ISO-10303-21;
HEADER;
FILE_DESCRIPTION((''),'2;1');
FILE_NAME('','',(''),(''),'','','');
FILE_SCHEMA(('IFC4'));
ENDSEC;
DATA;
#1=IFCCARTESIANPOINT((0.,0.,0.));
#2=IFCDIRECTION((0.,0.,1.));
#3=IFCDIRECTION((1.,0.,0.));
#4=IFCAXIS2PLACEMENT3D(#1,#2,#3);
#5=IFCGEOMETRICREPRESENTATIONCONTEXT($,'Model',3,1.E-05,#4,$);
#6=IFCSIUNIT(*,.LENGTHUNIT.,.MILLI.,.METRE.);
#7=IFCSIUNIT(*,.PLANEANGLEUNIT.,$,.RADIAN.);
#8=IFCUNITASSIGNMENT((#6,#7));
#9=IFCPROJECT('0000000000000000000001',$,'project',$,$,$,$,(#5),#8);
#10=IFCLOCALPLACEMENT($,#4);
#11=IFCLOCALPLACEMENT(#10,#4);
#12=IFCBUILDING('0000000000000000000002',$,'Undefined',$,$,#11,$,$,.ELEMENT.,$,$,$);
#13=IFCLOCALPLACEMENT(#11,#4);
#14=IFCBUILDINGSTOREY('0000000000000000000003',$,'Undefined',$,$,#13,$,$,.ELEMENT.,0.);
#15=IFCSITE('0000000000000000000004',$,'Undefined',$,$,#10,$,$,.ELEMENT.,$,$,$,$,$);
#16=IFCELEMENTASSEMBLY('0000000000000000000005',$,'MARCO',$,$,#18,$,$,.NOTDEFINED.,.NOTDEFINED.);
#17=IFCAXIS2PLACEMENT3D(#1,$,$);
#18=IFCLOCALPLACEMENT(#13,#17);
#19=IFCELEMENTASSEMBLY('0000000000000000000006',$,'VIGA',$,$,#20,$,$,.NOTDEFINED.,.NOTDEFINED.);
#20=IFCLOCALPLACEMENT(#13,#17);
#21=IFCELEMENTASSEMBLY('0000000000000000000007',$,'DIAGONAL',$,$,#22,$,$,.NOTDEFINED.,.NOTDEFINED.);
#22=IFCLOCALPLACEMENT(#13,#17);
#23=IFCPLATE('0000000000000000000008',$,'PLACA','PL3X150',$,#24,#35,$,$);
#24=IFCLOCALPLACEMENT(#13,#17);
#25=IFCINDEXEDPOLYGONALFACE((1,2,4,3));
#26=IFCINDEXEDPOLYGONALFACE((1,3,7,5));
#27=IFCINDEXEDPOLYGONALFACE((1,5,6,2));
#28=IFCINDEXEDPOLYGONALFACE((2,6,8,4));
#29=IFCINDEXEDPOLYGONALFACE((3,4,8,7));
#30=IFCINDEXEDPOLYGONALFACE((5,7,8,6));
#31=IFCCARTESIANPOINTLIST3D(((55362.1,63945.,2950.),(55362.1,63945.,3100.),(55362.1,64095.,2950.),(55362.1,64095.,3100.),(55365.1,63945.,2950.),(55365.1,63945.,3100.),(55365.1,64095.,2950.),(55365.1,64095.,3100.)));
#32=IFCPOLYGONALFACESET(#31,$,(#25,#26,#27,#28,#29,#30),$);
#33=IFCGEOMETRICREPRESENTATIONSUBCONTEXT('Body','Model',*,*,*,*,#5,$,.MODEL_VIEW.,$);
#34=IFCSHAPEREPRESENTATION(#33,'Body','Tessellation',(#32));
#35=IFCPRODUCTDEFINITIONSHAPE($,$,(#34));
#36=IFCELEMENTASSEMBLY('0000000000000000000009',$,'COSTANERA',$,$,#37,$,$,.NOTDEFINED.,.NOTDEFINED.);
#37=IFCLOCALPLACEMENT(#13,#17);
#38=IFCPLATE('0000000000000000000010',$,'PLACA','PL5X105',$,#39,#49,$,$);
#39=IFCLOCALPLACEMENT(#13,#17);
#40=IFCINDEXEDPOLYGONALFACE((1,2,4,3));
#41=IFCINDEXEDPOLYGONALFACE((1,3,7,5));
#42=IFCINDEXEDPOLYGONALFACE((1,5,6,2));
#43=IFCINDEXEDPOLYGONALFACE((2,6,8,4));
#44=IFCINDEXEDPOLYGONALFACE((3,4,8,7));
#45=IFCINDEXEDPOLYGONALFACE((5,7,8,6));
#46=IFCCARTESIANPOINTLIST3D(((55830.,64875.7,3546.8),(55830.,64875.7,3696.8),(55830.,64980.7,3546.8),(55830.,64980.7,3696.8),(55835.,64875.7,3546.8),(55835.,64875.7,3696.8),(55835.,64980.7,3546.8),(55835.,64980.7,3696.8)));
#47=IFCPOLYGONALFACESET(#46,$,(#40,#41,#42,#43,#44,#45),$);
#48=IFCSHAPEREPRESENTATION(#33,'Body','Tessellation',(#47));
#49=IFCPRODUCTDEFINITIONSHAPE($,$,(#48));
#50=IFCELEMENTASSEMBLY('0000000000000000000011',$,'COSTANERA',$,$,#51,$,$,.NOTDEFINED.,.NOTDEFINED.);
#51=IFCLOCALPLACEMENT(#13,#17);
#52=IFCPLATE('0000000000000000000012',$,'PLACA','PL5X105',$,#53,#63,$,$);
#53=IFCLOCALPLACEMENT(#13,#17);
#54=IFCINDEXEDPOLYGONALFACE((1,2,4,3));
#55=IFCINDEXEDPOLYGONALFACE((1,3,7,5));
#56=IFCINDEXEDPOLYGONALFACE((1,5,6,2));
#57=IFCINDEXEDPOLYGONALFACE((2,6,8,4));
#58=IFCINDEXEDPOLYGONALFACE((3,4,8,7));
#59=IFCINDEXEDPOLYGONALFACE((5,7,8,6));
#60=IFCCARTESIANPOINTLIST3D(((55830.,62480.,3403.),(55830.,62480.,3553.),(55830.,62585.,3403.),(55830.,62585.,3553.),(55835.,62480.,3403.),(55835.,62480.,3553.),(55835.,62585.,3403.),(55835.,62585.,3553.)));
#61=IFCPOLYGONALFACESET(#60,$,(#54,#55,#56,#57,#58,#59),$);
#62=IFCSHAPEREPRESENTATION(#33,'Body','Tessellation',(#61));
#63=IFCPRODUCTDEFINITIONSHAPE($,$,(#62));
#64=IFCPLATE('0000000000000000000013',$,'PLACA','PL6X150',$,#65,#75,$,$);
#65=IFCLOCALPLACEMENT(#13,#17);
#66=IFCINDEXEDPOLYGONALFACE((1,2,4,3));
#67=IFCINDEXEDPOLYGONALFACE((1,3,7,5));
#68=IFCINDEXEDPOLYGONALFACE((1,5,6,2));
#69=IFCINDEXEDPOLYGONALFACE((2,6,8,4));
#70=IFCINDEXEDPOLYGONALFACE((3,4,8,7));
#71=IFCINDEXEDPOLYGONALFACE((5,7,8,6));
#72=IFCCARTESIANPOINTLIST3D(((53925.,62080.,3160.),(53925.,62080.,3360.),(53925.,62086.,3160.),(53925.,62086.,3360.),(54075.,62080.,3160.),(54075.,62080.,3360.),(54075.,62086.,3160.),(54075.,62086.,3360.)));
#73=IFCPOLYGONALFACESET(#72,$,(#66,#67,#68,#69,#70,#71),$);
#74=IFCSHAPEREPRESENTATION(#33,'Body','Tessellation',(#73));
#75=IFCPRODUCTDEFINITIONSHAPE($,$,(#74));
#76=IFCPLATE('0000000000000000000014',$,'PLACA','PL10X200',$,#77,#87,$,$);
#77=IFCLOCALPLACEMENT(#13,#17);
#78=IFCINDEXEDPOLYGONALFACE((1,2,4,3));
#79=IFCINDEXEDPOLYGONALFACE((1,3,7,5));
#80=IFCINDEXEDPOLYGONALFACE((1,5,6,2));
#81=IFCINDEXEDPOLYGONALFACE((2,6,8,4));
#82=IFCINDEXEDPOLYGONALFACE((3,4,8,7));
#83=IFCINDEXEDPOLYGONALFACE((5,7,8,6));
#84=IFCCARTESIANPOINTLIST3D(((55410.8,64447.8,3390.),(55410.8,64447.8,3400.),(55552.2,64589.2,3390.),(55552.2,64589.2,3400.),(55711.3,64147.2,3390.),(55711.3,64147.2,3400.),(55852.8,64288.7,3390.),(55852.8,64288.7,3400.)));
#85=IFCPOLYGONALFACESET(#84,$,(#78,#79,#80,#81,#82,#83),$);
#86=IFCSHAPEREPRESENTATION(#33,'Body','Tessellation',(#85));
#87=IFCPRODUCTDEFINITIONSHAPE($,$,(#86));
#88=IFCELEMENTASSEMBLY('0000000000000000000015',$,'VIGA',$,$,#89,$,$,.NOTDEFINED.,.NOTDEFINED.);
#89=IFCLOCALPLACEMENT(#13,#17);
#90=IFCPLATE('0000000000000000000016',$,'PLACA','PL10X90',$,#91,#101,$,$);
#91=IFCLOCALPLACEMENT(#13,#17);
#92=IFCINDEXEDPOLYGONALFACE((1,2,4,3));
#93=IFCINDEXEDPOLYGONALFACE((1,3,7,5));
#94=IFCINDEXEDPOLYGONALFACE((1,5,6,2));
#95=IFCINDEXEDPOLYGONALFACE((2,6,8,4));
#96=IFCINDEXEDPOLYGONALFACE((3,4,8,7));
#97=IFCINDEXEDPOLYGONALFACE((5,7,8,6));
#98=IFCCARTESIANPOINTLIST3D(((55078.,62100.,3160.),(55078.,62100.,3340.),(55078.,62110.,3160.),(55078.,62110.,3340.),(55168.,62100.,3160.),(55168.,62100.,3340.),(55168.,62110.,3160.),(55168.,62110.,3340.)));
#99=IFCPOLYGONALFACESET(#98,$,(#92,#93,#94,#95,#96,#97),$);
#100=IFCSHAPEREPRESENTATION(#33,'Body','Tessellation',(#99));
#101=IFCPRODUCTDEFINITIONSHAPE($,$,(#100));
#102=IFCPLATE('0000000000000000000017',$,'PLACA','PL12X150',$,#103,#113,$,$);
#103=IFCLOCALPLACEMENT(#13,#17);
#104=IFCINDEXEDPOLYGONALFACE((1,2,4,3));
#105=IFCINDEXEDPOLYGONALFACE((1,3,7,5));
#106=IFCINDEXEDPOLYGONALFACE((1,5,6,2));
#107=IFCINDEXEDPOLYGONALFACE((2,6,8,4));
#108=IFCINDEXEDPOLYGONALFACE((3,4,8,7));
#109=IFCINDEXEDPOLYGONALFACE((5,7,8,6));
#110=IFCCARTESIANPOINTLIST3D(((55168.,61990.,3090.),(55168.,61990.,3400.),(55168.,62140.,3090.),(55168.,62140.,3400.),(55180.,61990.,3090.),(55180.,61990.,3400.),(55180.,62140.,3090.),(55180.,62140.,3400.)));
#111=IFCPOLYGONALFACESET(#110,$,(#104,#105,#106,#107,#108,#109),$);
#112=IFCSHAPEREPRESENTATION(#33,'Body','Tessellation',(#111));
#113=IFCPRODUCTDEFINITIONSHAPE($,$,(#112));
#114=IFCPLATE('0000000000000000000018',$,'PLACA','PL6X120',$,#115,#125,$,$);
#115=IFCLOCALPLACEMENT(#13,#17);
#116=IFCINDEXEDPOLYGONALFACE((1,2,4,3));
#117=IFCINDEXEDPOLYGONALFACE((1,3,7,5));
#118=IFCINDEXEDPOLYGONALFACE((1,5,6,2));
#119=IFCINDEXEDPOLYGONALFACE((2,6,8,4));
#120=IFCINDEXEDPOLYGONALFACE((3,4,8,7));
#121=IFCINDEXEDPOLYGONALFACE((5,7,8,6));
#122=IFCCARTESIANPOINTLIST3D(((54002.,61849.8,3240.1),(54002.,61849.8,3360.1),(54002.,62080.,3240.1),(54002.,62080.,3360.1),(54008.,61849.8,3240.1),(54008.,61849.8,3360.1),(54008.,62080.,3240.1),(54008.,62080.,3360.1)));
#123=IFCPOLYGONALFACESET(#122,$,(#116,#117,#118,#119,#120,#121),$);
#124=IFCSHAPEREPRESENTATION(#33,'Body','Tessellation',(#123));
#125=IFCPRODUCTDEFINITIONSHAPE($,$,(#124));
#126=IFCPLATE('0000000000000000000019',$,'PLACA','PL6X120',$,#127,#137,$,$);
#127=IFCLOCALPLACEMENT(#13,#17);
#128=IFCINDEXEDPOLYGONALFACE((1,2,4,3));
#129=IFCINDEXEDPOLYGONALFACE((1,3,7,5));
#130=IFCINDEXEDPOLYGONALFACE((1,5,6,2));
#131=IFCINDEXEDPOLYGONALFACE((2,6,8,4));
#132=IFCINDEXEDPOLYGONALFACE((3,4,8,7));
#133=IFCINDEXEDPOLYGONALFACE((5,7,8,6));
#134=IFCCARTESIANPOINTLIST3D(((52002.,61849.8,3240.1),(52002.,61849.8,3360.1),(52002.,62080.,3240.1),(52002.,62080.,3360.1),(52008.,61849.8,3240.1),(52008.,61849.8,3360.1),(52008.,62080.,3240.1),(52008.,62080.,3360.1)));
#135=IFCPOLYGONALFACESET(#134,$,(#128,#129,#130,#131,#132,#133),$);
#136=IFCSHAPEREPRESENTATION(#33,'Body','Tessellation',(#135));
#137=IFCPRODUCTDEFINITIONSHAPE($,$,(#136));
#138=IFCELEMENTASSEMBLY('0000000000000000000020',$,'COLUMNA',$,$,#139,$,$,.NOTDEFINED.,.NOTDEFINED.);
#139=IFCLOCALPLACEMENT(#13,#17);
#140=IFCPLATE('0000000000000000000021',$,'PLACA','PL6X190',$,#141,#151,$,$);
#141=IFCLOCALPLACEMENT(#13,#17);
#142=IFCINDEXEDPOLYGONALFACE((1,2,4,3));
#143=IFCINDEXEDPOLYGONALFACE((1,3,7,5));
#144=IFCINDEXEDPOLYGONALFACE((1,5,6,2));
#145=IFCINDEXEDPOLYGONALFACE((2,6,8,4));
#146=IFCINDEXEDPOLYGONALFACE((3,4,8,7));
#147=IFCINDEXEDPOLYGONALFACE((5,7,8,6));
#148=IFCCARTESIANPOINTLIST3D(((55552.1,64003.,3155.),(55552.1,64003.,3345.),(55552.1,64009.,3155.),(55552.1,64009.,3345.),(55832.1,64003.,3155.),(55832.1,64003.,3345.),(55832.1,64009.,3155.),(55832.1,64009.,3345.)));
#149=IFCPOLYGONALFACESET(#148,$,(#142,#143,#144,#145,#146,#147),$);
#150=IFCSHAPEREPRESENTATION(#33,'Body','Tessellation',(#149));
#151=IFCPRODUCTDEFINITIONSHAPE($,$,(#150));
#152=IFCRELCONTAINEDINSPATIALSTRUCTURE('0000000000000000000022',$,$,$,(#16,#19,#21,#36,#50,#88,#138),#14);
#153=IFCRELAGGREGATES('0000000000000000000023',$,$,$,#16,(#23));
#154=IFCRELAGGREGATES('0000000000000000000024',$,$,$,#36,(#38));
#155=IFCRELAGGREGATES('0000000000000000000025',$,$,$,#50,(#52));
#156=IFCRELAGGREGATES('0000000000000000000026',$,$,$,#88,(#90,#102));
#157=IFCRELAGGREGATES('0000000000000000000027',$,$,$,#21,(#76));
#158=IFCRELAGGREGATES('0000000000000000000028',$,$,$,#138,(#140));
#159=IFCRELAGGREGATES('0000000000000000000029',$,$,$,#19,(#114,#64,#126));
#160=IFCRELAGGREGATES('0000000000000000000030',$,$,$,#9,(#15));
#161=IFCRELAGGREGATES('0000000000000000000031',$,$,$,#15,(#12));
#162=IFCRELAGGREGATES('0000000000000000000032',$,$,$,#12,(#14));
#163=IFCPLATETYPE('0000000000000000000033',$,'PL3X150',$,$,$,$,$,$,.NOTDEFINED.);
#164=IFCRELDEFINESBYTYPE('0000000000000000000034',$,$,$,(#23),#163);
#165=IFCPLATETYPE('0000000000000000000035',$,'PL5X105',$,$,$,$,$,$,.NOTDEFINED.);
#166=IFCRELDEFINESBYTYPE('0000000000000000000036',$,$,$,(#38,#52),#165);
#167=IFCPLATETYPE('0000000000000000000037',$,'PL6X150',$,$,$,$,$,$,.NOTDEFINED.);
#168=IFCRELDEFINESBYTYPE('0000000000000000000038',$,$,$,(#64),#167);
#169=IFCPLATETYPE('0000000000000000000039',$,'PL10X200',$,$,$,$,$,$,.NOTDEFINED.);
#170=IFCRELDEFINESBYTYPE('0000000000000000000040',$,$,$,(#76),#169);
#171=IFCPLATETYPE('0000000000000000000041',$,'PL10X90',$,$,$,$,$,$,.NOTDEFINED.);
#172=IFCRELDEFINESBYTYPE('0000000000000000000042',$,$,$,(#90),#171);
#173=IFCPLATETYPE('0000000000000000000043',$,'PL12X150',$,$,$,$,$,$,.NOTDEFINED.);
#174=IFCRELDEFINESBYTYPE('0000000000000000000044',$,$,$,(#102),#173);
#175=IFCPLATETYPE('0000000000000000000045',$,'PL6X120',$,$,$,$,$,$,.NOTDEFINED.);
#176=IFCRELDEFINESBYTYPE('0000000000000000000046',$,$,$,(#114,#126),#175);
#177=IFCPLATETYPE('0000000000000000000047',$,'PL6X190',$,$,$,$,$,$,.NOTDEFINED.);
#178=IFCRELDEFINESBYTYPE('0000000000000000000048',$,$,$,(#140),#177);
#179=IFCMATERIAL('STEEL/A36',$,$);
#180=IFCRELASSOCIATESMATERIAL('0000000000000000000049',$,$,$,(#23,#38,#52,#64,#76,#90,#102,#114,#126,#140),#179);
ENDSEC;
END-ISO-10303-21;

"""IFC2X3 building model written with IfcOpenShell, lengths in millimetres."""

from ifc_helpers import new_model, si_unit, frame, origin_with_axes, origin_2d_with_axis, place, context, subcontext, project, spatial, polyline, rectangle, outline, extrude, material, type_object, element, aggregate, save


model = new_model("IFC2X3")

# Units and contexts
model_context = context("Model", 3, precision=1e-05, world=origin_with_axes())
body_context = subcontext(model_context, "Body", "Model", "MODEL_VIEW")
ifc_project = project(units=[si_unit("LENGTHUNIT", "METRE", prefix="MILLI"), si_unit("PLANEANGLEUNIT", "RADIAN")], contexts=[model_context])

# Site, building, storey
site_placement = place(None, origin_with_axes())
site = spatial("IfcSite", under=ifc_project, at=site_placement, Name="Undefined", CompositionType="ELEMENT")
building_placement = place(site_placement, origin_with_axes())
building = spatial("IfcBuilding", under=site, at=building_placement, Name="Undefined", CompositionType="ELEMENT")
storey_placement = place(building_placement, origin_with_axes())
storey = spatial("IfcBuildingStorey", under=building, at=storey_placement, Name="Undefined", CompositionType="ELEMENT", Elevation=0.0)

# Element assembly
assembly_1_placement = place(storey_placement, origin_with_axes())
assembly_1 = element("IfcElementAssembly", 1, at=assembly_1_placement, inside=storey, Name="MARCO", AssemblyPlace="NOTDEFINED", PredefinedType="NOTDEFINED")
ifc_material_1 = material(Name="STEEL/A36")

# Element assembly
assembly_2_placement = place(storey_placement, origin_with_axes())
assembly_2 = element("IfcElementAssembly", 2, at=assembly_2_placement, inside=storey, Name="VIGA", AssemblyPlace="NOTDEFINED", PredefinedType="NOTDEFINED")

# Element assembly
assembly_3_placement = place(storey_placement, origin_with_axes())
assembly_3 = element("IfcElementAssembly", 3, at=assembly_3_placement, inside=storey, Name="DIAGONAL", AssemblyPlace="NOTDEFINED", PredefinedType="NOTDEFINED")

# Plate
plate_type_1 = type_object("IfcPlateType", Name="PL3X150", PredefinedType="NOTDEFINED")
plate_1_placement = place(assembly_1_placement, frame((55363.6, 64095.0, 2950.0), z_axis=(-1.0, 0.0, 0.0), x_axis=(0.0, -1.0, 0.0)))
plate_1 = element("IfcPlate", 4, at=plate_1_placement, type_object=plate_type_1, material=ifc_material_1, Name="PLACA", Description="PL3X150", context=body_context, shape_type="SweptSolid", body=[
    extrude(outline(polyline([(0.0, 0.0), (150.0, 0.0), (150.0, 150.0), (0.0, 150.0), (0.0, 0.0)])), frame((0.0, 0.0, -1.5), z_axis=(0.0, 0.0, 1.0), x_axis=(1.0, 0.0, 0.0)), (0.0, 0.0, 1.0), 3.0),
])
aggregate(assembly_1, [plate_1])

# Element assemblies, plates
assembly_4_placement = place(storey_placement, origin_with_axes())
assembly_4 = element("IfcElementAssembly", 5, at=assembly_4_placement, inside=storey, Name="COSTANERA", AssemblyPlace="NOTDEFINED", PredefinedType="NOTDEFINED")
plate_type_2 = type_object("IfcPlateType", Name="PL5X105", PredefinedType="NOTDEFINED")
plate_2_placement = place(assembly_4_placement, frame((55832.5, 64980.7, 3546.8), z_axis=(-1.0, 0.0, 0.0), x_axis=(0.0, -1.0, 0.0)))
plate_2 = element("IfcPlate", 6, at=plate_2_placement, type_object=plate_type_2, material=ifc_material_1, Name="PLACA", Description="PL5X105", context=body_context, shape_type="SweptSolid", body=[
    extrude(outline(polyline([(0.0, 0.0), (105.0, 0.0), (105.0, 150.0), (0.0, 150.0), (0.0, 0.0)])), frame((0.0, 0.0, -2.5), z_axis=(0.0, 0.0, 1.0), x_axis=(1.0, 0.0, 0.0)), (0.0, 0.0, 1.0), 5.0),
])
aggregate(assembly_4, [plate_2])
assembly_5_placement = place(storey_placement, origin_with_axes())
assembly_5 = element("IfcElementAssembly", 7, at=assembly_5_placement, inside=storey, Name="COSTANERA", AssemblyPlace="NOTDEFINED", PredefinedType="NOTDEFINED")
plate_3_placement = place(assembly_5_placement, frame((55832.5, 62585.0, 3403.0), z_axis=(-1.0, 0.0, 0.0), x_axis=(0.0, -1.0, 0.0)))
plate_3 = element("IfcPlate", 8, at=plate_3_placement, type_object=plate_type_2, material=ifc_material_1, Name="PLACA", Description="PL5X105", context=body_context, shape_type="SweptSolid", body=[
    extrude(outline(polyline([(0.0, 0.0), (105.0, 0.0), (105.0, 150.0), (0.0, 150.0), (0.0, 0.0)])), frame((0.0, 0.0, -2.5), z_axis=(0.0, 0.0, 1.0), x_axis=(1.0, 0.0, 0.0)), (0.0, 0.0, 1.0), 5.0),
])
aggregate(assembly_5, [plate_3])

# Plates
plate_type_3 = type_object("IfcPlateType", Name="PL6X150", PredefinedType="NOTDEFINED")
plate_4_placement = place(assembly_2_placement, frame((53925.0, 62083.0, 3360.0), z_axis=(0.0, 1.0, 0.0), x_axis=(1.0, 0.0, 0.0)))
plate_4 = element("IfcPlate", 9, at=plate_4_placement, type_object=plate_type_3, material=ifc_material_1, Name="PLACA", Description="PL6X150", context=body_context, shape_type="SweptSolid", body=[
    extrude(outline(polyline([(0.0, 0.0), (150.0, 0.0), (150.0, 200.0), (0.0, 200.0), (0.0, 0.0)])), frame((0.0, 0.0, -3.0), z_axis=(0.0, 0.0, 1.0), x_axis=(1.0, 0.0, 0.0)), (0.0, 0.0, 1.0), 6.0),
])
plate_type_4 = type_object("IfcPlateType", Name="PL10X200", PredefinedType="NOTDEFINED")
plate_5_placement = place(assembly_3_placement, frame((55782.0, 64218.0, 3395.0), z_axis=(0.0, 0.0, -1.0), x_axis=(-0.707107, 0.707107, 0.0)))
plate_5 = element("IfcPlate", 10, at=plate_5_placement, type_object=plate_type_4, material=ifc_material_1, Name="PLACA", Description="PL10X200", context=body_context, shape_type="SweptSolid", body=[
    extrude(outline(polyline([(0.0, -100.0), (0.0, 100.0), (425.0, 100.0), (425.0, -100.0), (0.0, -100.0)])), frame((0.0, 0.0, -5.0), z_axis=(0.0, 0.0, 1.0), x_axis=(1.0, 0.0, 0.0)), (0.0, 0.0, 1.0), 10.0),
])

# Element assembly, plates
assembly_6_placement = place(storey_placement, origin_with_axes())
assembly_6 = element("IfcElementAssembly", 11, at=assembly_6_placement, inside=storey, Name="VIGA", AssemblyPlace="NOTDEFINED", PredefinedType="NOTDEFINED")
plate_type_5 = type_object("IfcPlateType", Name="PL10X90", PredefinedType="NOTDEFINED")
plate_6_placement = place(assembly_6_placement, frame((55168.0, 62105.0, 3340.0), z_axis=(0.0, 1.0, 0.0), x_axis=(0.0, 0.0, -1.0)))
plate_6 = element("IfcPlate", 12, at=plate_6_placement, type_object=plate_type_5, material=ifc_material_1, Name="PLACA", Description="PL10X90", context=body_context, shape_type="SweptSolid", body=[
    extrude(outline(polyline([(0.0, 0.0), (180.0, 0.0), (180.0, 90.0), (0.0, 90.0), (0.0, 0.0)])), frame((0.0, 0.0, -5.0), z_axis=(0.0, 0.0, 1.0), x_axis=(1.0, 0.0, 0.0)), (0.0, 0.0, 1.0), 10.0),
])
plate_type_6 = type_object("IfcPlateType", Name="PL12X150", PredefinedType="NOTDEFINED")
plate_7_placement = place(assembly_6_placement, frame((55174.0, 62065.0, 3090.0), z_axis=(0.0, 1.0, 0.0), x_axis=(0.0, 0.0, 1.0)))
plate_7 = element("IfcPlate", 13, at=plate_7_placement, type_object=plate_type_6, material=ifc_material_1, Name="PLACA", Description="PL12X150", context=body_context, shape_type="SweptSolid", body=[
    extrude(rectangle(XDim=12.0, YDim=150.0, at=origin_2d_with_axis()), frame((310.0, 0.0, 0.0), z_axis=(-1.0, 0.0, 0.0), x_axis=(0.0, -1.0, 0.0)), (0.0, 0.0, 1.0), 310.0),
])
aggregate(assembly_6, [plate_6, plate_7])

# Plates
plate_type_7 = type_object("IfcPlateType", Name="PL6X120", PredefinedType="NOTDEFINED")
plate_8_placement = place(assembly_2_placement, frame((54005.0, 62080.0, 3360.1), z_axis=(-1.0, 0.0, 0.0), x_axis=(0.0, 0.0, -1.0)))
plate_8 = element("IfcPlate", 14, at=plate_8_placement, type_object=plate_type_7, material=ifc_material_1, Name="PLACA", Description="PL6X120", context=body_context, shape_type="SweptSolid", body=[
    extrude(outline(polyline([(0.0, 0.0), (120.0, 0.0), (120.0, 230.2), (0.0, 230.2), (0.0, 0.0)])), frame((0.0, 0.0, -3.0), z_axis=(0.0, 0.0, 1.0), x_axis=(1.0, 0.0, 0.0)), (0.0, 0.0, 1.0), 6.0),
])
plate_9_placement = place(assembly_2_placement, frame((52005.0, 62080.0, 3360.1), z_axis=(-1.0, 0.0, 0.0), x_axis=(0.0, 0.0, -1.0)))
plate_9 = element("IfcPlate", 15, at=plate_9_placement, type_object=plate_type_7, material=ifc_material_1, Name="PLACA", Description="PL6X120", context=body_context, shape_type="SweptSolid", body=[
    extrude(outline(polyline([(0.0, 0.0), (120.0, 0.0), (120.0, 230.2), (0.0, 230.2), (0.0, 0.0)])), frame((0.0, 0.0, -3.0), z_axis=(0.0, 0.0, 1.0), x_axis=(1.0, 0.0, 0.0)), (0.0, 0.0, 1.0), 6.0),
])

# Element assembly, plate
assembly_7_placement = place(storey_placement, origin_with_axes())
assembly_7 = element("IfcElementAssembly", 16, at=assembly_7_placement, inside=storey, Name="COLUMNA", AssemblyPlace="NOTDEFINED", PredefinedType="NOTDEFINED")
plate_type_8 = type_object("IfcPlateType", Name="PL6X190", PredefinedType="NOTDEFINED")
plate_10_placement = place(assembly_7_placement, frame((55552.1, 64006.0, 3250.0), z_axis=(0.0, -1.0, 0.0), x_axis=(1.0, 0.0, 0.0)))
plate_10 = element("IfcPlate", 17, at=plate_10_placement, type_object=plate_type_8, material=ifc_material_1, Name="PLACA", Description="PL6X190", context=body_context, shape_type="SweptSolid", body=[
    extrude(outline(polyline([(0.0, -95.0), (0.0, 95.0), (280.0, 95.0), (280.0, -95.0), (0.0, -95.0)])), frame((0.0, 0.0, -3.0), z_axis=(0.0, 0.0, 1.0), x_axis=(1.0, 0.0, 0.0)), (0.0, 0.0, 1.0), 6.0),
])

aggregate(assembly_3, [plate_5])
aggregate(assembly_7, [plate_10])
aggregate(assembly_2, [plate_8, plate_4, plate_9])

save(model, "model.ifc")
